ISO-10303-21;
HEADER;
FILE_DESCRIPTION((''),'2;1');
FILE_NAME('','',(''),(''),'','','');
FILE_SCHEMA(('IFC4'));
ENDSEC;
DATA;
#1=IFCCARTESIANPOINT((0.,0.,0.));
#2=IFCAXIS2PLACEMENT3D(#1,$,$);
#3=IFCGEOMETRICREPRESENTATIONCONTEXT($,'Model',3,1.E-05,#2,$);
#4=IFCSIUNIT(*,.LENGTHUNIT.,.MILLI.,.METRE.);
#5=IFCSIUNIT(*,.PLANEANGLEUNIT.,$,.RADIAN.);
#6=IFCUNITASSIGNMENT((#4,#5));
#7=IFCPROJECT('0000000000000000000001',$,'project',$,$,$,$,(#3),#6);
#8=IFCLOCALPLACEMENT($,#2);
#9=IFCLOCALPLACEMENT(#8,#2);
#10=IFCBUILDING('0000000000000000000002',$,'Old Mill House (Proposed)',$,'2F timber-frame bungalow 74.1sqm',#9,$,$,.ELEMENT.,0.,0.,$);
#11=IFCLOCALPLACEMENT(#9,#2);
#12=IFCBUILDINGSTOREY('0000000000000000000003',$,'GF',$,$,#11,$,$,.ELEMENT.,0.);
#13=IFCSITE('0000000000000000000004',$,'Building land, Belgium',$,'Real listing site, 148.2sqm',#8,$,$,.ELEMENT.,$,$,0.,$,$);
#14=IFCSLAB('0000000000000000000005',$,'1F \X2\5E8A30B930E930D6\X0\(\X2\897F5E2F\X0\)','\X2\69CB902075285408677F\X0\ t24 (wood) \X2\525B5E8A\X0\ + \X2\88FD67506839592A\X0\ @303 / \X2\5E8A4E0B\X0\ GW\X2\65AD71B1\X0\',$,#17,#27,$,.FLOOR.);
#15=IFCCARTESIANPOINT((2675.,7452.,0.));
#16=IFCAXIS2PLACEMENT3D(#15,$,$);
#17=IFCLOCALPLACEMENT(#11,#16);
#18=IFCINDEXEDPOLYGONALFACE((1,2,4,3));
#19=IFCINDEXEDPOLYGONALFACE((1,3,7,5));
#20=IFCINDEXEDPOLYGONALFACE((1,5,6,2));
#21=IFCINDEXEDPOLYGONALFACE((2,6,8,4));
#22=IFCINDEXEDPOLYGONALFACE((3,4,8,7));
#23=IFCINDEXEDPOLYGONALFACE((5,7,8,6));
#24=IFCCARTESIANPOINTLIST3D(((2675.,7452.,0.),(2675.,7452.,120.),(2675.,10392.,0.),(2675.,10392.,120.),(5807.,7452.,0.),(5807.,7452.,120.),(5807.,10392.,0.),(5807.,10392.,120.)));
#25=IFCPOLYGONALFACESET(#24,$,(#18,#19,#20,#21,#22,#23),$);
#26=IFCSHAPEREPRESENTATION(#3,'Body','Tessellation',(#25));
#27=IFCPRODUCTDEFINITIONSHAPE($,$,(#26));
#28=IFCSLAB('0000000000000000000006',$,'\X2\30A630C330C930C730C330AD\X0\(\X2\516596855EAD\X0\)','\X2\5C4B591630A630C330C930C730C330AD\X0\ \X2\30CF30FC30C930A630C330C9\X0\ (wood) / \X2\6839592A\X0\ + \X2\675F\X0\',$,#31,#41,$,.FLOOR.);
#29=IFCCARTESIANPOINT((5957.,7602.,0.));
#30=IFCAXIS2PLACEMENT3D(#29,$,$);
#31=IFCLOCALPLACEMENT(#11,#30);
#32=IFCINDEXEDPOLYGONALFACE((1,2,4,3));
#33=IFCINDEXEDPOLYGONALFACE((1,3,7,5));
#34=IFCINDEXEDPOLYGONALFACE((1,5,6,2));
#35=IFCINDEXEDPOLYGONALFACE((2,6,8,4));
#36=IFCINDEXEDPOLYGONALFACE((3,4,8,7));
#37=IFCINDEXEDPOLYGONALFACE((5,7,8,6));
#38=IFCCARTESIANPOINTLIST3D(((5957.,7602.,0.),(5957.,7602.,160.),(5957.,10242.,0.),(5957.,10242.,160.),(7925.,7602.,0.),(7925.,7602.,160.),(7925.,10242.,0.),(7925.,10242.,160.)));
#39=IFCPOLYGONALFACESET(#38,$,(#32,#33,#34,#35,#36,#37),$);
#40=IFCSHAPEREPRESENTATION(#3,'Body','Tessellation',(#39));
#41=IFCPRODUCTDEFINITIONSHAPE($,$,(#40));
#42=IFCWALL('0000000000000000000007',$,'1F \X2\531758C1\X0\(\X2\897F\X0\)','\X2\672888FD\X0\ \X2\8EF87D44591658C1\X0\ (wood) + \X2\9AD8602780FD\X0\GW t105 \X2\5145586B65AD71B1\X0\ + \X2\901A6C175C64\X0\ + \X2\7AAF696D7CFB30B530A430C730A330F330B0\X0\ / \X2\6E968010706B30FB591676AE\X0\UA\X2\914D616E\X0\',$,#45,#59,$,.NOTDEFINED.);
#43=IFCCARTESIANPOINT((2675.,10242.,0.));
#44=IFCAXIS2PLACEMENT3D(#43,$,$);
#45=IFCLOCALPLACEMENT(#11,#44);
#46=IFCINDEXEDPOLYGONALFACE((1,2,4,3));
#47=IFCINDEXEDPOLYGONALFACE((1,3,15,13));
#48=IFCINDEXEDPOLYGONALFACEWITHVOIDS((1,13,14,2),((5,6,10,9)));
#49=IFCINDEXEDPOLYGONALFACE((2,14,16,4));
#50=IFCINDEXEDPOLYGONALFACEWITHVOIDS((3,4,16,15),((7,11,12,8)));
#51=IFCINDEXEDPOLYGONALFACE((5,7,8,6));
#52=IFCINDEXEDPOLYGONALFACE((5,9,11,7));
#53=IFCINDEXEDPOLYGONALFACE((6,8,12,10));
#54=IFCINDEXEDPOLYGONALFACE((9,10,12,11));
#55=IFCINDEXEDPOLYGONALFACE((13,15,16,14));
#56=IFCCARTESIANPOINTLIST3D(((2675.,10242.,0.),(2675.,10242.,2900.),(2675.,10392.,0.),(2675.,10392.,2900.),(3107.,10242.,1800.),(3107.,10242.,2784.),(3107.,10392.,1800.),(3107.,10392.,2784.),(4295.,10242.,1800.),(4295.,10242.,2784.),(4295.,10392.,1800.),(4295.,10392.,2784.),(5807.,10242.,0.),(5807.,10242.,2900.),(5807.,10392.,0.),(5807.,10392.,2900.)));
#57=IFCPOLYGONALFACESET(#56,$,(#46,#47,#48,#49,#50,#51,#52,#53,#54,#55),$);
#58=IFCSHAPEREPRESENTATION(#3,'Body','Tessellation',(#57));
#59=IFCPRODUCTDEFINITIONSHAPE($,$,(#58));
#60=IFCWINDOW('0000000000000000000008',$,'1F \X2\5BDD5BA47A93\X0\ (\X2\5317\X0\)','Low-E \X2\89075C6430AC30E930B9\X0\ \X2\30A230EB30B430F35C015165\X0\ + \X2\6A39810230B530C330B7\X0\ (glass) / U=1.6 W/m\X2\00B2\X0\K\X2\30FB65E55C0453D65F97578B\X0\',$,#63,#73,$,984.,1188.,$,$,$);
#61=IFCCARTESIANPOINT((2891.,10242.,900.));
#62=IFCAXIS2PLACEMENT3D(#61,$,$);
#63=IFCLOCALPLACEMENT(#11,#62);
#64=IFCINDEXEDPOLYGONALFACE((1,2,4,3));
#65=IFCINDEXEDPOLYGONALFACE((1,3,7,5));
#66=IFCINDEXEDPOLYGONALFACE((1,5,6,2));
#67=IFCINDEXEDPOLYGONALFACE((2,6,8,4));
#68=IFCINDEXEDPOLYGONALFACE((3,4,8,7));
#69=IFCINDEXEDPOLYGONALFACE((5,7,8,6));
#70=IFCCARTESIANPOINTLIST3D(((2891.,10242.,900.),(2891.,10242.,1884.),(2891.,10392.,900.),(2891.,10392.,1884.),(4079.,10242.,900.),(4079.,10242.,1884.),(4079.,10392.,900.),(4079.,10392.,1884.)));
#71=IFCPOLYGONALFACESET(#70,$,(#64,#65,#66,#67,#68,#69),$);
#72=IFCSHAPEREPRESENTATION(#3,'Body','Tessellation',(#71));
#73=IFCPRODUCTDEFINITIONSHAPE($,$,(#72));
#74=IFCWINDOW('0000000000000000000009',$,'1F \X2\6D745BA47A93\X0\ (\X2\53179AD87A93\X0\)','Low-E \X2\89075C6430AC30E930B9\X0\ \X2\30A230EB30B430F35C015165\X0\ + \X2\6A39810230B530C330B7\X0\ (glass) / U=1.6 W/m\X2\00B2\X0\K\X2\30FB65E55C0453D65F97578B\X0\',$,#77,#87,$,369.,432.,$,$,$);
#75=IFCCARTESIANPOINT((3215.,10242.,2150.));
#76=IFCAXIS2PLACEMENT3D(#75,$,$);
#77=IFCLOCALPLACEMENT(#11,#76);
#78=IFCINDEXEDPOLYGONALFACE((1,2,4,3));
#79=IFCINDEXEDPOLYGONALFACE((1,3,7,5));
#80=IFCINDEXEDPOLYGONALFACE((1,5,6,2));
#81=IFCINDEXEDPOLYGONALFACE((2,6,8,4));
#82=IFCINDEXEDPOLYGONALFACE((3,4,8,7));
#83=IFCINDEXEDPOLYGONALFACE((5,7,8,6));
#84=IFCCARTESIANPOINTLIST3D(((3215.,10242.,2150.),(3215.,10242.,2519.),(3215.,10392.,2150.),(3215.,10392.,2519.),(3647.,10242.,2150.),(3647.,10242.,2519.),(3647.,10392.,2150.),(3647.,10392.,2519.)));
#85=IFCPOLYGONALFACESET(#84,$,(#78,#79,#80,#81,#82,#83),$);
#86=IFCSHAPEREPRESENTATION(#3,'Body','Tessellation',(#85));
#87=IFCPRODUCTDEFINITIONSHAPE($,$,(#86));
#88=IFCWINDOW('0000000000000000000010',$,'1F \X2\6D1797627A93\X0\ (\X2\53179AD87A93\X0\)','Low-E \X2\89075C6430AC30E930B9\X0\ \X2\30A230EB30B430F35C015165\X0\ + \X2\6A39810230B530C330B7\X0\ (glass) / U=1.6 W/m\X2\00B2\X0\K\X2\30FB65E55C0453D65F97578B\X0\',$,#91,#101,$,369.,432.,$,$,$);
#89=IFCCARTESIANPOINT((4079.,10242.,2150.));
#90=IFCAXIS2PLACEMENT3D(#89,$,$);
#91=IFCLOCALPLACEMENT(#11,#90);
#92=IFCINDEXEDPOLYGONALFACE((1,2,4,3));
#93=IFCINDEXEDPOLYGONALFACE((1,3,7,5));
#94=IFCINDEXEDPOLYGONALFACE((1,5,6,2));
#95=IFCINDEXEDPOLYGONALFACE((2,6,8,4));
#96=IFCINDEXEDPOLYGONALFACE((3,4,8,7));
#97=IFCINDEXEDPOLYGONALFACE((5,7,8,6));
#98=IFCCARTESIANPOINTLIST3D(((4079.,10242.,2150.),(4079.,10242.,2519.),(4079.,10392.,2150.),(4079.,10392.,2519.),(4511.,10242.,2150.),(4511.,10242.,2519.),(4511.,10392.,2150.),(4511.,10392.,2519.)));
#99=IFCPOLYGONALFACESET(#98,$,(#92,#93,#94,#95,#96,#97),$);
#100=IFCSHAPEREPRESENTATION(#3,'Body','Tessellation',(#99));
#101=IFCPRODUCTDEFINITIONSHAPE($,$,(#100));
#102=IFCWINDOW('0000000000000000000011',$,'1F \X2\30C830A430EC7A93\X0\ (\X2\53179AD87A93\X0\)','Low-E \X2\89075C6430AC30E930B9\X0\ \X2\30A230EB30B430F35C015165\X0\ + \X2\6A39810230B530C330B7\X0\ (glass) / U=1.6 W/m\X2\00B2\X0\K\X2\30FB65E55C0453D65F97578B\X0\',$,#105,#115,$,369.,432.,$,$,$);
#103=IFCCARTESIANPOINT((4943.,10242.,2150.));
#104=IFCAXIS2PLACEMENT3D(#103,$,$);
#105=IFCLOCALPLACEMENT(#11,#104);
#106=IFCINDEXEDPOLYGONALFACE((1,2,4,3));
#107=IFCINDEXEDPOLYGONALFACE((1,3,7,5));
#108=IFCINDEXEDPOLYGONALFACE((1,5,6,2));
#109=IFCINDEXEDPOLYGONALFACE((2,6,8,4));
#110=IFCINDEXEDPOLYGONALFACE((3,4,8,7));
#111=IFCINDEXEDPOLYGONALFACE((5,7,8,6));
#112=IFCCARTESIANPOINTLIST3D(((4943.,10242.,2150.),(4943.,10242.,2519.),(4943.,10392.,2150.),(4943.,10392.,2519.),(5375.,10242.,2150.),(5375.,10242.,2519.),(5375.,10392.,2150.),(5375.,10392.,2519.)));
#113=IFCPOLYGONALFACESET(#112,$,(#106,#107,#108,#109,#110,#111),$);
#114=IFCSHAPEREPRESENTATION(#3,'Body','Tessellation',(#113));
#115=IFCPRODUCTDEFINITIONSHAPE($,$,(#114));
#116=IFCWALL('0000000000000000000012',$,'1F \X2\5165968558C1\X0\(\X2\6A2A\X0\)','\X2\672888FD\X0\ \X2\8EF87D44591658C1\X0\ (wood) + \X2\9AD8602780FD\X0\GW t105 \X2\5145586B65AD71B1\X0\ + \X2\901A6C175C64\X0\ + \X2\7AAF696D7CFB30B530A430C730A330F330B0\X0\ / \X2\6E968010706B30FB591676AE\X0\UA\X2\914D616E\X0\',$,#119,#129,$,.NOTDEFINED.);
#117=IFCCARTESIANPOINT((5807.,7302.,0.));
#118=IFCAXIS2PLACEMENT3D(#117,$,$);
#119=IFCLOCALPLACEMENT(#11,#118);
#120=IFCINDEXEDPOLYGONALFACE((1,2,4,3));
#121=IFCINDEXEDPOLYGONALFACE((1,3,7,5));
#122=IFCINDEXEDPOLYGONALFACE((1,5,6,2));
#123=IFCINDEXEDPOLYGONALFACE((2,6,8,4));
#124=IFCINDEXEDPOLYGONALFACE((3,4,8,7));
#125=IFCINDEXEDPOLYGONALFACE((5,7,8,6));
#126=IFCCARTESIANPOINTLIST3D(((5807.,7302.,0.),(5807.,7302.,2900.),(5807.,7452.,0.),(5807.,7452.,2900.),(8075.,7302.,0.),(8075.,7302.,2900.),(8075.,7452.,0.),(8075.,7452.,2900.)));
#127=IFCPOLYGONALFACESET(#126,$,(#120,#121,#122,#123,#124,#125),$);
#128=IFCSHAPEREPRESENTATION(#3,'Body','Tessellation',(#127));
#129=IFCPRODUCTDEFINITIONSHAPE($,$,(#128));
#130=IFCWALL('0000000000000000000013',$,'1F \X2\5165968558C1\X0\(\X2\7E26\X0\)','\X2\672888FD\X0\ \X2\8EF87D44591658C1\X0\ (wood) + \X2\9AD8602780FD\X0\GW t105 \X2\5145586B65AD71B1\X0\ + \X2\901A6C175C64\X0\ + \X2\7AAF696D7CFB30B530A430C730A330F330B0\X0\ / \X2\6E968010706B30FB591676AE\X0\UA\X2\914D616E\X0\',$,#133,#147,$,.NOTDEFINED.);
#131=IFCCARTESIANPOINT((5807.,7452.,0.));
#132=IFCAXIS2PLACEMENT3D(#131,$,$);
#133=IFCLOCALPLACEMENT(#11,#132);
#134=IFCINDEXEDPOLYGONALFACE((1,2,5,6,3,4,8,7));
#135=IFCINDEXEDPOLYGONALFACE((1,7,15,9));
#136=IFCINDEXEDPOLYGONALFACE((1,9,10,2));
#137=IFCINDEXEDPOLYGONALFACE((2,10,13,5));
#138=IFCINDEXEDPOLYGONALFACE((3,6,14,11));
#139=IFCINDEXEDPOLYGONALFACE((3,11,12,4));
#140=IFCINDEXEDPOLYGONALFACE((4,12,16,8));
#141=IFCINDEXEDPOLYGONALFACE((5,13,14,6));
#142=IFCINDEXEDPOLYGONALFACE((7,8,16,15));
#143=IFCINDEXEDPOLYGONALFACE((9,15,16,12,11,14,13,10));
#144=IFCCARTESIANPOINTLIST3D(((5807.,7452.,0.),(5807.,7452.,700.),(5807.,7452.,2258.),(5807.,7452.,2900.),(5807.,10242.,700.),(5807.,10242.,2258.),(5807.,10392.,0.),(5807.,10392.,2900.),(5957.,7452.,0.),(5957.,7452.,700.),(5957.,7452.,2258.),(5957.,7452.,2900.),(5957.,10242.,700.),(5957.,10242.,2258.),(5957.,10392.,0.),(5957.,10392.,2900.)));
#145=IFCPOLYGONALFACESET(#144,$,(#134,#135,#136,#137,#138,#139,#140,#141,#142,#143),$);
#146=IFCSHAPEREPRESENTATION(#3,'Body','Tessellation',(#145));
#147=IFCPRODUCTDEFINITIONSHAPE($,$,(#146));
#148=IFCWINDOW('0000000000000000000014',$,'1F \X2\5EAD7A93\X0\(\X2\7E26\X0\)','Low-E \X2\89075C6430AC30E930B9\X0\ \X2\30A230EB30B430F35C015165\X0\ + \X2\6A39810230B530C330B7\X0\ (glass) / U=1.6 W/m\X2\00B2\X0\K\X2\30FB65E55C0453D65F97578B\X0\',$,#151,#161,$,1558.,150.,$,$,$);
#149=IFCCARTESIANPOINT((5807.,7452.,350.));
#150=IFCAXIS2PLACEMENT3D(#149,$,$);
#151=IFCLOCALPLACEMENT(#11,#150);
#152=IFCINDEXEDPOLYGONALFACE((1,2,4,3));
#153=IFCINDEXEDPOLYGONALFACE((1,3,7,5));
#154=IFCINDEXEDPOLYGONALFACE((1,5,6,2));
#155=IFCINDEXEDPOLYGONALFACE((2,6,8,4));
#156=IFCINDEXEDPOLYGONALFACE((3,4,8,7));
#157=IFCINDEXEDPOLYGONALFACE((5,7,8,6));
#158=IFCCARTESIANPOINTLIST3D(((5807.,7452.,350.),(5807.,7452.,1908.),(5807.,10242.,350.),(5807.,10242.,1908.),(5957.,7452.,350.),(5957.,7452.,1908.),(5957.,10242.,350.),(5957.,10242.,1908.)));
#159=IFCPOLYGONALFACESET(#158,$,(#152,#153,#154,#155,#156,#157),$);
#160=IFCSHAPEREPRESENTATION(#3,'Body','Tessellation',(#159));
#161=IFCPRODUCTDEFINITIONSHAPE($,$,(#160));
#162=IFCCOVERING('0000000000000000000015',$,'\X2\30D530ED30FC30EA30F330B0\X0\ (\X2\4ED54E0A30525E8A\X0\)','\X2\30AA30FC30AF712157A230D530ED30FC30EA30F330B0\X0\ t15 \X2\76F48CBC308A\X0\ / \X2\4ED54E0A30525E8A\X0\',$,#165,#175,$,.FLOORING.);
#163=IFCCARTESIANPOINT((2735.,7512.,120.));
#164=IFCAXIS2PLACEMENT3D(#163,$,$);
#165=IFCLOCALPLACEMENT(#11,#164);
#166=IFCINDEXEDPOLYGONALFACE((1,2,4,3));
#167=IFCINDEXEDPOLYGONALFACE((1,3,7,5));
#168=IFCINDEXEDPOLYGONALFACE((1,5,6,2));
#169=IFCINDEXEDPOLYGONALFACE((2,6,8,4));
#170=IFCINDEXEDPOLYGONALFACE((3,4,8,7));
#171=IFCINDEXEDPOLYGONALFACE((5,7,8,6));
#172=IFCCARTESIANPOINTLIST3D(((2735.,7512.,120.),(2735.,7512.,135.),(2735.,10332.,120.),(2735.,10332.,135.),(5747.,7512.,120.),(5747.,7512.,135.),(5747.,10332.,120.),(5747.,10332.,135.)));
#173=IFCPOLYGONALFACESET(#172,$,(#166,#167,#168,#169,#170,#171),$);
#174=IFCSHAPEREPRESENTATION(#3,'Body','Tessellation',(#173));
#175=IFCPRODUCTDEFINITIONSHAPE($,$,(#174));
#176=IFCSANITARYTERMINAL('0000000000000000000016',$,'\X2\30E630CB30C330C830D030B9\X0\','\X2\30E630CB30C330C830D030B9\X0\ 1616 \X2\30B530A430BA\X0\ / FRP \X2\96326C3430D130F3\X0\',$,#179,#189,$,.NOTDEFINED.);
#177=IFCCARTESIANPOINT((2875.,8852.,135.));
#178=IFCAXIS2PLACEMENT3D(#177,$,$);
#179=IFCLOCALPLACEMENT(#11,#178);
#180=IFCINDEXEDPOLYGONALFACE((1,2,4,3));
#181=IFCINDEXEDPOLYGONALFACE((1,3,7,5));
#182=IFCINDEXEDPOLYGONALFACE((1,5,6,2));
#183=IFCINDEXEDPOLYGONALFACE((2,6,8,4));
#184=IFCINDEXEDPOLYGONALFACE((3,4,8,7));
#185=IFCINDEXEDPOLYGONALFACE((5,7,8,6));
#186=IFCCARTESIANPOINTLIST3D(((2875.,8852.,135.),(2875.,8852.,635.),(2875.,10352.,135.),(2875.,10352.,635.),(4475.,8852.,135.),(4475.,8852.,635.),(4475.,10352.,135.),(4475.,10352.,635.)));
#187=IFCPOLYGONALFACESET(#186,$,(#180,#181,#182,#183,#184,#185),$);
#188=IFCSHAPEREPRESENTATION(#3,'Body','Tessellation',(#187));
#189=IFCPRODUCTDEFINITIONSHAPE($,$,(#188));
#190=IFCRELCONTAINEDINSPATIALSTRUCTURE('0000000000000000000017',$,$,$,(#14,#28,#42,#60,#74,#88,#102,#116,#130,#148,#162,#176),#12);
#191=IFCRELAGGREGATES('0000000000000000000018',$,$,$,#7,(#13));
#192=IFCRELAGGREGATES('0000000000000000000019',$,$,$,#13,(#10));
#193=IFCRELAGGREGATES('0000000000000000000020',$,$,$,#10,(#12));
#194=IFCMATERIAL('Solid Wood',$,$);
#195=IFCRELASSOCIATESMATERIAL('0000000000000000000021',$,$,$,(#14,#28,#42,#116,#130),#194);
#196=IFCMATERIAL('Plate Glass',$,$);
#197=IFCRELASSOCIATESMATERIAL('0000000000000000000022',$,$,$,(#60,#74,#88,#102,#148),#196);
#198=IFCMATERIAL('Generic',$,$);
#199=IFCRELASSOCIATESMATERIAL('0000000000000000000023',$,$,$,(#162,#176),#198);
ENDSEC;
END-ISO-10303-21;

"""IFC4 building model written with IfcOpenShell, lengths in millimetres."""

from ifc_helpers import new_model, si_unit, frame, frame_2d, origin, place, context, project, spatial, rectangle, extrude, material, element, fill, save


model = new_model("IFC4")

# Units and contexts
model_context = context("Model", 3, precision=1e-05, world=origin())
ifc_project = project(units=[si_unit("LENGTHUNIT", "METRE", prefix="MILLI"), si_unit("PLANEANGLEUNIT", "RADIAN")], contexts=[model_context])

# Site, building, storey
site_placement = place(None, origin())
site = spatial("IfcSite", under=ifc_project, at=site_placement, Name="Building land, Belgium", ObjectType="Real listing site, 148.2sqm", CompositionType="ELEMENT", RefElevation=0.0)
building_placement = place(site_placement, origin())
building = spatial("IfcBuilding", under=site, at=building_placement, Name="Old Mill House (Proposed)", ObjectType="2F timber-frame bungalow 74.1sqm", CompositionType="ELEMENT", ElevationOfRefHeight=0.0, ElevationOfTerrain=0.0)
storey_placement = place(building_placement, origin())
storey = spatial("IfcBuildingStorey", under=building, at=storey_placement, Name="GF", CompositionType="ELEMENT", Elevation=0.0)

# Slabs
ifc_material_1 = material(Name="Solid Wood")
slab_1_placement = place(storey_placement, frame((2675.0, 7452.0, 0.0)))
element("IfcSlab", 1, at=slab_1_placement, inside=storey, material=ifc_material_1, Name="1F 床スラブ(西帯)", Description="構造用合板 t24 (wood) 剛床 + 製材根太 @303 / 床下 GW断熱", PredefinedType="FLOOR", context=model_context, shape_type="SweptSolid", body=[
    extrude(rectangle(XDim=3132.0, YDim=2940.0, at=frame_2d((1566.0, 1470.0))), frame((2675.0, 7452.0, 0.0)), (0.0, 0.0, 1.0), 120.0),
])
slab_2_placement = place(storey_placement, frame((5957.0, 7602.0, 0.0)))
element("IfcSlab", 2, at=slab_2_placement, inside=storey, material=ifc_material_1, Name="ウッドデッキ(入隅庭)", Description="屋外ウッドデッキ ハードウッド (wood) / 根太 + 束", PredefinedType="FLOOR", context=model_context, shape_type="SweptSolid", body=[
    extrude(rectangle(XDim=1968.0, YDim=2640.0, at=frame_2d((984.0, 1320.0))), frame((5957.0, 7602.0, 0.0)), (0.0, 0.0, 1.0), 160.0),
])

# Wall, openings, windows
wall_1_placement = place(storey_placement, frame((2675.0, 10242.0, 0.0)))
wall_1 = element("IfcWall", 3, at=wall_1_placement, inside=storey, material=ifc_material_1, Name="1F 北壁(西)", Description="木製 軸組外壁 (wood) + 高性能GW t105 充填断熱 + 通気層 + 窯業系サイディング / 準耐火・外皮UA配慮", PredefinedType="NOTDEFINED", context=model_context, shape_type="SweptSolid", body=[
    extrude(rectangle(XDim=3132.0, YDim=150.0, at=frame_2d((1566.0, 75.0))), frame((2675.0, 10242.0, 0.0)), (0.0, 0.0, 1.0), 2900.0),
])
opening_1_placement = place(storey_placement, frame((2891.0, 10242.0, 900.0)))
opening_1 = element("IfcOpeningElement", 4, at=opening_1_placement, cuts=wall_1, PredefinedType="NOTDEFINED", context=model_context, shape_type="SweptSolid", body=[
    extrude(rectangle(XDim=1188.0, YDim=150.0, at=frame_2d((594.0, 75.0))), frame((2891.0, 10242.0, 900.0)), (0.0, 0.0, 1.0), 984.0),
])
opening_2_placement = place(storey_placement, frame((3215.0, 10242.0, 2150.0)))
opening_2 = element("IfcOpeningElement", 5, at=opening_2_placement, cuts=wall_1, PredefinedType="NOTDEFINED", context=model_context, shape_type="SweptSolid", body=[
    extrude(rectangle(XDim=432.0, YDim=150.0, at=frame_2d((216.0, 75.0))), frame((3215.0, 10242.0, 2150.0)), (0.0, 0.0, 1.0), 369.0),
])
opening_3_placement = place(storey_placement, frame((4079.0, 10242.0, 2150.0)))
opening_3 = element("IfcOpeningElement", 6, at=opening_3_placement, cuts=wall_1, PredefinedType="NOTDEFINED", context=model_context, shape_type="SweptSolid", body=[
    extrude(rectangle(XDim=432.0, YDim=150.0, at=frame_2d((216.0, 75.0))), frame((4079.0, 10242.0, 2150.0)), (0.0, 0.0, 1.0), 369.0),
])
opening_4_placement = place(storey_placement, frame((4943.0, 10242.0, 2150.0)))
opening_4 = element("IfcOpeningElement", 7, at=opening_4_placement, cuts=wall_1, PredefinedType="NOTDEFINED", context=model_context, shape_type="SweptSolid", body=[
    extrude(rectangle(XDim=432.0, YDim=150.0, at=frame_2d((216.0, 75.0))), frame((4943.0, 10242.0, 2150.0)), (0.0, 0.0, 1.0), 369.0),
])
ifc_material_2 = material(Name="Plate Glass")
window_1_placement = place(storey_placement, frame((2891.0, 10242.0, 900.0)))
window_1 = element("IfcWindow", 8, at=window_1_placement, inside=storey, material=ifc_material_2, Name="1F 寝室窓 (北)", Description="Low-E 複層ガラス アルゴン封入 + 樹脂サッシ (glass) / U=1.6 W/m²K・日射取得型", OverallHeight=984.0, OverallWidth=1188.0, context=model_context, shape_type="SweptSolid", body=[
    extrude(rectangle(XDim=1188.0, YDim=150.0, at=frame_2d((594.0, 75.0))), frame((2891.0, 10242.0, 900.0)), (0.0, 0.0, 1.0), 984.0),
])
fill(opening_1, window_1)
window_2_placement = place(storey_placement, frame((3215.0, 10242.0, 2150.0)))
window_2 = element("IfcWindow", 9, at=window_2_placement, inside=storey, material=ifc_material_2, Name="1F 浴室窓 (北高窓)", Description="Low-E 複層ガラス アルゴン封入 + 樹脂サッシ (glass) / U=1.6 W/m²K・日射取得型", OverallHeight=369.0, OverallWidth=432.0, context=model_context, shape_type="SweptSolid", body=[
    extrude(rectangle(XDim=432.0, YDim=150.0, at=frame_2d((216.0, 75.0))), frame((3215.0, 10242.0, 2150.0)), (0.0, 0.0, 1.0), 369.0),
])
fill(opening_2, window_2)
window_3_placement = place(storey_placement, frame((4079.0, 10242.0, 2150.0)))
window_3 = element("IfcWindow", 10, at=window_3_placement, inside=storey, material=ifc_material_2, Name="1F 洗面窓 (北高窓)", Description="Low-E 複層ガラス アルゴン封入 + 樹脂サッシ (glass) / U=1.6 W/m²K・日射取得型", OverallHeight=369.0, OverallWidth=432.0, context=model_context, shape_type="SweptSolid", body=[
    extrude(rectangle(XDim=432.0, YDim=150.0, at=frame_2d((216.0, 75.0))), frame((4079.0, 10242.0, 2150.0)), (0.0, 0.0, 1.0), 369.0),
])
fill(opening_3, window_3)
window_4_placement = place(storey_placement, frame((4943.0, 10242.0, 2150.0)))
window_4 = element("IfcWindow", 11, at=window_4_placement, inside=storey, material=ifc_material_2, Name="1F トイレ窓 (北高窓)", Description="Low-E 複層ガラス アルゴン封入 + 樹脂サッシ (glass) / U=1.6 W/m²K・日射取得型", OverallHeight=369.0, OverallWidth=432.0, context=model_context, shape_type="SweptSolid", body=[
    extrude(rectangle(XDim=432.0, YDim=150.0, at=frame_2d((216.0, 75.0))), frame((4943.0, 10242.0, 2150.0)), (0.0, 0.0, 1.0), 369.0),
])
fill(opening_4, window_4)

# Wall
wall_2_placement = place(storey_placement, frame((5807.0, 7302.0, 0.0)))
element("IfcWall", 12, at=wall_2_placement, inside=storey, material=ifc_material_1, Name="1F 入隅壁(横)", Description="木製 軸組外壁 (wood) + 高性能GW t105 充填断熱 + 通気層 + 窯業系サイディング / 準耐火・外皮UA配慮", PredefinedType="NOTDEFINED", context=model_context, shape_type="SweptSolid", body=[
    extrude(rectangle(XDim=2268.0, YDim=150.0, at=frame_2d((1134.0, 75.0))), frame((5807.0, 7302.0, 0.0)), (0.0, 0.0, 1.0), 2900.0),
])

# Wall, opening, window
wall_3_placement = place(storey_placement, frame((5807.0, 7452.0, 0.0)))
wall_3 = element("IfcWall", 13, at=wall_3_placement, inside=storey, material=ifc_material_1, Name="1F 入隅壁(縦)", Description="木製 軸組外壁 (wood) + 高性能GW t105 充填断熱 + 通気層 + 窯業系サイディング / 準耐火・外皮UA配慮", PredefinedType="NOTDEFINED", context=model_context, shape_type="SweptSolid", body=[
    extrude(rectangle(XDim=150.0, YDim=2940.0, at=frame_2d((75.0, 1470.0))), frame((5807.0, 7452.0, 0.0)), (0.0, 0.0, 1.0), 2900.0),
])
opening_5_placement = place(storey_placement, frame((5807.0, 7452.0, 350.0)))
opening_5 = element("IfcOpeningElement", 14, at=opening_5_placement, cuts=wall_3, PredefinedType="NOTDEFINED", context=model_context, shape_type="SweptSolid", body=[
    extrude(rectangle(XDim=150.0, YDim=2790.0, at=frame_2d((75.0, 1395.0))), frame((5807.0, 7452.0, 350.0)), (0.0, 0.0, 1.0), 1558.0),
])
window_5_placement = place(storey_placement, frame((5807.0, 7452.0, 350.0)))
window_5 = element("IfcWindow", 15, at=window_5_placement, inside=storey, material=ifc_material_2, Name="1F 庭窓(縦)", Description="Low-E 複層ガラス アルゴン封入 + 樹脂サッシ (glass) / U=1.6 W/m²K・日射取得型", OverallHeight=1558.0, OverallWidth=150.0, context=model_context, shape_type="SweptSolid", body=[
    extrude(rectangle(XDim=150.0, YDim=2790.0, at=frame_2d((75.0, 1395.0))), frame((5807.0, 7452.0, 350.0)), (0.0, 0.0, 1.0), 1558.0),
])
fill(opening_5, window_5)

# Covering
ifc_material_3 = material(Name="Generic")
covering_placement = place(storey_placement, frame((2735.0, 7512.0, 120.0)))
element("IfcCovering", 16, at=covering_placement, inside=storey, material=ifc_material_3, Name="フローリング (仕上げ床)", Description="オーク無垢フローリング t15 直貼り / 仕上げ床", PredefinedType="FLOORING", context=model_context, shape_type="SweptSolid", body=[
    extrude(rectangle(XDim=3012.0, YDim=2820.0, at=frame_2d((1506.0, 1410.0))), frame((2735.0, 7512.0, 120.0)), (0.0, 0.0, 1.0), 15.0),
])

# Sanitary terminal
sanitary_terminal_1_placement = place(storey_placement, frame((2875.0, 8852.0, 135.0)))
element("IfcSanitaryTerminal", 17, at=sanitary_terminal_1_placement, inside=storey, material=ifc_material_3, Name="ユニットバス", Description="ユニットバス 1616 サイズ / FRP 防水パン", PredefinedType="NOTDEFINED", context=model_context, shape_type="SweptSolid", body=[
    extrude(rectangle(XDim=1600.0, YDim=1500.0, at=frame_2d((800.0, 750.0))), frame((2875.0, 8852.0, 135.0)), (0.0, 0.0, 1.0), 500.0),
])

save(model, "model.ifc")
